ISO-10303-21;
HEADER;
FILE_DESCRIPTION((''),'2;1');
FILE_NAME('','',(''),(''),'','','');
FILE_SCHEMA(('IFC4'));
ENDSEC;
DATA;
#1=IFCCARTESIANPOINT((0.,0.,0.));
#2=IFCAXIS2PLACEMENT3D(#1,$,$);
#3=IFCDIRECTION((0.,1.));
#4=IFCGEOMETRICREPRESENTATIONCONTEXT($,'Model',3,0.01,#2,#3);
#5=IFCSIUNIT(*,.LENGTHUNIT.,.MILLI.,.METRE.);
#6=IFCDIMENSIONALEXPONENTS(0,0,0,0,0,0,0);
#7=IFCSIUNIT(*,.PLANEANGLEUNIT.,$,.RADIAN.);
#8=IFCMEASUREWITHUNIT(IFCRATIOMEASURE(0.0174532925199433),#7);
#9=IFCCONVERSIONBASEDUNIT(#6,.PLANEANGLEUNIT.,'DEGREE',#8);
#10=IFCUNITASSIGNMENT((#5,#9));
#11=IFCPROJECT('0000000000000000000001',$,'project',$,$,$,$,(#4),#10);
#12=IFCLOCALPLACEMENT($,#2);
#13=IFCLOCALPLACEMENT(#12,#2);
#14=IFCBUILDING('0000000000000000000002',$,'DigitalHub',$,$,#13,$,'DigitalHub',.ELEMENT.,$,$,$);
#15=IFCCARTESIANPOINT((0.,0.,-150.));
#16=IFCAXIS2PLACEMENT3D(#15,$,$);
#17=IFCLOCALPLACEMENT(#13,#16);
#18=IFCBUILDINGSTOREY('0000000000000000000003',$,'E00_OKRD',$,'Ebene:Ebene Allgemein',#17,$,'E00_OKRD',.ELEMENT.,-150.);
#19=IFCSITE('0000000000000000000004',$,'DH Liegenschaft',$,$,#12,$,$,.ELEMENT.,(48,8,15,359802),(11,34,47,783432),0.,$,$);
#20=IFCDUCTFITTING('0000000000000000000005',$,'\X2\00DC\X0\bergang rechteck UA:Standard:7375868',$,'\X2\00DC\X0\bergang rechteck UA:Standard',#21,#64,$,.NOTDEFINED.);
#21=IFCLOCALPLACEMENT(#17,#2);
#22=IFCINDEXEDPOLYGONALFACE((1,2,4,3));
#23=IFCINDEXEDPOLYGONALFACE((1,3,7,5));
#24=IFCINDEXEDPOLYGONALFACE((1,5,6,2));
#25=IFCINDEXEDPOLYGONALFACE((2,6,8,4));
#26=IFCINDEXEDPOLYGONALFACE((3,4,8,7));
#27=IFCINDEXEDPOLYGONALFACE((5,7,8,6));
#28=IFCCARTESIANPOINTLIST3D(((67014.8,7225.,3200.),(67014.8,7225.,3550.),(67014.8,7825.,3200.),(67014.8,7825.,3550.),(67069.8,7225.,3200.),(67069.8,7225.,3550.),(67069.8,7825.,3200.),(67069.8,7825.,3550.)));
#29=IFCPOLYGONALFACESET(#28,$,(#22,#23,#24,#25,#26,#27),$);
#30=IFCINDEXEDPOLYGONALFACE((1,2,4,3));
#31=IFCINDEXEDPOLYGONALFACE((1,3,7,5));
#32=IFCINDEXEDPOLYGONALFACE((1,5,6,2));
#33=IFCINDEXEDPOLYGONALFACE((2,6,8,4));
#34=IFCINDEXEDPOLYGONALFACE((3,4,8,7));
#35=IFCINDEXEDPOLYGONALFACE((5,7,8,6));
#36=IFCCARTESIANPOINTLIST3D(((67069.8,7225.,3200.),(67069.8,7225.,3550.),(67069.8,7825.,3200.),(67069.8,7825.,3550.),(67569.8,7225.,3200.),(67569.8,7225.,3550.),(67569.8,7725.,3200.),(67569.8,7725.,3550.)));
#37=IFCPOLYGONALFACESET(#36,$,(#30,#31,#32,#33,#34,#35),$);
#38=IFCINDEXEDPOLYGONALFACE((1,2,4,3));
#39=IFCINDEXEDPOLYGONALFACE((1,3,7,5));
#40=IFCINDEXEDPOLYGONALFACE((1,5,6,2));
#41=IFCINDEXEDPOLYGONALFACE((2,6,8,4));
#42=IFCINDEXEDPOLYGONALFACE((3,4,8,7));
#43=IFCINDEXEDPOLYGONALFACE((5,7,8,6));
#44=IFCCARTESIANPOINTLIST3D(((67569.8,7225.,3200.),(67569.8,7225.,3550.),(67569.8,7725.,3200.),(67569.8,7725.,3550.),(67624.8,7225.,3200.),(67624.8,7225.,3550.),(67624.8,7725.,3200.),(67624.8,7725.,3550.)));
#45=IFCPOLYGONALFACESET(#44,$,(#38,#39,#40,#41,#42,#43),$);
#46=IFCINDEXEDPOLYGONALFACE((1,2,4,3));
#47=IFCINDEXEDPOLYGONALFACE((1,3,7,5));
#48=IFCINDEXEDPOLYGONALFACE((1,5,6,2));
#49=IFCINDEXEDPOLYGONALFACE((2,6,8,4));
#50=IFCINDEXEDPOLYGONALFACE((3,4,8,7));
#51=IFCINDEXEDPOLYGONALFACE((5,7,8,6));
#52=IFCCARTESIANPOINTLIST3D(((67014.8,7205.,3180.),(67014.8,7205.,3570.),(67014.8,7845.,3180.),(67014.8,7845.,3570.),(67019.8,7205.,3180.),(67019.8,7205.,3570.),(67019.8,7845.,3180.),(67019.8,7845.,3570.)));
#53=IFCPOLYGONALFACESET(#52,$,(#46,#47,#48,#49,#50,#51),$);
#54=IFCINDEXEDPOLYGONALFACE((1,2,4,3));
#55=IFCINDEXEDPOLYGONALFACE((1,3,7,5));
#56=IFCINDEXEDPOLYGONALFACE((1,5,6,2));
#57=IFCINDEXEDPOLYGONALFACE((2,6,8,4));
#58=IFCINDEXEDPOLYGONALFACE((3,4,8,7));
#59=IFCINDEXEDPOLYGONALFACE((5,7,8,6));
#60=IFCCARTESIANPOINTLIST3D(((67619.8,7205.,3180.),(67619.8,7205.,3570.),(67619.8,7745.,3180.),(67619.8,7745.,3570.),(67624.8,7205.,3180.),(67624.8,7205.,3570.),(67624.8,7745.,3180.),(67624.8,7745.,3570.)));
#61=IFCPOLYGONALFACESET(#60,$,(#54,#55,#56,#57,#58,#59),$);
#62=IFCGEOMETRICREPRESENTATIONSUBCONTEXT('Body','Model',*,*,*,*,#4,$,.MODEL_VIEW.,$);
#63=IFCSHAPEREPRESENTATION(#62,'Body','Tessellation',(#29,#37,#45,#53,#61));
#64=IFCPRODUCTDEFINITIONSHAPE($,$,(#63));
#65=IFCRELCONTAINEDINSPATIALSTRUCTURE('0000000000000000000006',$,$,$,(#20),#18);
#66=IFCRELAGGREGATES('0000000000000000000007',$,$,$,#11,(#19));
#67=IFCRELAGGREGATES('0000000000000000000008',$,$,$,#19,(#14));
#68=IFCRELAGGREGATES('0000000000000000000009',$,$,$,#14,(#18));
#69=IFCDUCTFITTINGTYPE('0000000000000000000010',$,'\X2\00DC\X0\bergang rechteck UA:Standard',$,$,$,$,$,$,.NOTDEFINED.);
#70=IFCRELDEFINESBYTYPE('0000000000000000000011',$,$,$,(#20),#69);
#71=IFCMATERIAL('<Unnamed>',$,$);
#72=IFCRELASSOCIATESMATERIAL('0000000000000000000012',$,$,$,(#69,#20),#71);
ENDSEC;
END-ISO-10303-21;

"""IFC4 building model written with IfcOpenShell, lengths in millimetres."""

from ifc_helpers import new_model, entity, si_unit, converted_unit, direction, frame, origin, place, context, subcontext, project, spatial, indexed_curve, outline, extrude, source, transform, mapped, material, type_object, type_shapes, element, save


model = new_model("IFC4")

# Units and contexts
model_context = context("Model", 3, precision=0.01, world=origin(), true_north=direction((0.0, 1.0)))
body_context = subcontext(model_context, "Body", "Model", "MODEL_VIEW")
ifc_project = project(units=[si_unit("LENGTHUNIT", "METRE", prefix="MILLI"), converted_unit("PLANEANGLEUNIT", "DEGREE", entity("IfcRatioMeasure", 0.0174532925199433), si_unit("PLANEANGLEUNIT", "RADIAN"), dimensions=[0, 0, 0, 0, 0, 0, 0])], contexts=[model_context])

# Site, building, storey
site_placement = place(None, origin())
site = spatial("IfcSite", under=ifc_project, at=site_placement, Name="DH Liegenschaft", CompositionType="ELEMENT", RefLatitude=(48, 8, 15, 359802), RefLongitude=(11, 34, 47, 783432), RefElevation=0.0)
building_placement = place(site_placement, origin())
building = spatial("IfcBuilding", under=site, at=building_placement, Name="DigitalHub", LongName="DigitalHub", CompositionType="ELEMENT")
storey_placement = place(building_placement, frame((0.0, 0.0, -150.0)))
storey = spatial("IfcBuildingStorey", under=building, at=storey_placement, Name="E00_OKRD", ObjectType="Ebene:Ebene Allgemein", LongName="E00_OKRD", CompositionType="ELEMENT", Elevation=-150.0)

# Shared definitions
ifc_material_1 = material(Name="<Unnamed>")

# Duct fitting
duct_fitting_type_1 = type_object("IfcDuctFittingType", Name="Übergang rechteck UA:Standard", PredefinedType="NOTDEFINED", material=ifc_material_1)
shared_shape_1 = source(origin(), body_context, "Body", "SweptSolid", [
    extrude(outline(indexed_curve([(-27.5, -300.0), (27.5, -300.0), (27.5, 300.0), (-27.5, 300.0), (-27.5, -300.0)], self_intersect=False)), frame((582.5, -50.0, -175.0)), (0.0, 0.0, 1.0), 350.0),
    extrude(outline(indexed_curve([(-201.0, -269.7), (308.9, -269.7), (191.2, 318.7), (-299.1, 220.6), (-201.0, -269.7)], self_intersect=False)), frame((305.0, -25.0, -175.0), z_axis=(0.0, 0.0, 1.0), x_axis=(0.980581, -0.196116, 0.0)), (0.0, 0.0, 1.0), 350.0),
    extrude(outline(indexed_curve([(-27.5, -250.0), (27.5, -250.0), (27.5, 250.0), (-27.5, 250.0), (-27.5, -250.0)], self_intersect=False)), frame((27.5, 0.0, -175.0)), (0.0, 0.0, 1.0), 350.0),
    extrude(outline(indexed_curve([(-2.5, -320.0), (2.5, -320.0), (2.5, 320.0), (-2.5, 320.0), (-2.5, -320.0)], self_intersect=False)), frame((607.5, -50.0, -195.0)), (0.0, 0.0, 1.0), 390.0),
    extrude(outline(indexed_curve([(-2.5, -270.0), (2.5, -270.0), (2.5, 270.0), (-2.5, 270.0), (-2.5, -270.0)], self_intersect=False)), frame((2.5, 0.0, -195.0)), (0.0, 0.0, 1.0), 390.0),
])
type_shapes(duct_fitting_type_1, [shared_shape_1])
duct_fitting_1_placement = place(storey_placement, frame((67624.8, 7475.0, 3375.0), z_axis=(0.0, 0.0, 1.0), x_axis=(-1.0, 0.0, 0.0)))
element("IfcDuctFitting", 1, at=duct_fitting_1_placement, inside=storey, type_object=duct_fitting_type_1, material=ifc_material_1, Name="Übergang rechteck UA:Standard:7375868", ObjectType="Übergang rechteck UA:Standard", PredefinedType="NOTDEFINED", context=body_context, shape_type="MappedRepresentation", body=[
    mapped(shared_shape_1, transform((0.0, 0.0, 0.0), scale=1.0)),
])

save(model, "model.ifc")
